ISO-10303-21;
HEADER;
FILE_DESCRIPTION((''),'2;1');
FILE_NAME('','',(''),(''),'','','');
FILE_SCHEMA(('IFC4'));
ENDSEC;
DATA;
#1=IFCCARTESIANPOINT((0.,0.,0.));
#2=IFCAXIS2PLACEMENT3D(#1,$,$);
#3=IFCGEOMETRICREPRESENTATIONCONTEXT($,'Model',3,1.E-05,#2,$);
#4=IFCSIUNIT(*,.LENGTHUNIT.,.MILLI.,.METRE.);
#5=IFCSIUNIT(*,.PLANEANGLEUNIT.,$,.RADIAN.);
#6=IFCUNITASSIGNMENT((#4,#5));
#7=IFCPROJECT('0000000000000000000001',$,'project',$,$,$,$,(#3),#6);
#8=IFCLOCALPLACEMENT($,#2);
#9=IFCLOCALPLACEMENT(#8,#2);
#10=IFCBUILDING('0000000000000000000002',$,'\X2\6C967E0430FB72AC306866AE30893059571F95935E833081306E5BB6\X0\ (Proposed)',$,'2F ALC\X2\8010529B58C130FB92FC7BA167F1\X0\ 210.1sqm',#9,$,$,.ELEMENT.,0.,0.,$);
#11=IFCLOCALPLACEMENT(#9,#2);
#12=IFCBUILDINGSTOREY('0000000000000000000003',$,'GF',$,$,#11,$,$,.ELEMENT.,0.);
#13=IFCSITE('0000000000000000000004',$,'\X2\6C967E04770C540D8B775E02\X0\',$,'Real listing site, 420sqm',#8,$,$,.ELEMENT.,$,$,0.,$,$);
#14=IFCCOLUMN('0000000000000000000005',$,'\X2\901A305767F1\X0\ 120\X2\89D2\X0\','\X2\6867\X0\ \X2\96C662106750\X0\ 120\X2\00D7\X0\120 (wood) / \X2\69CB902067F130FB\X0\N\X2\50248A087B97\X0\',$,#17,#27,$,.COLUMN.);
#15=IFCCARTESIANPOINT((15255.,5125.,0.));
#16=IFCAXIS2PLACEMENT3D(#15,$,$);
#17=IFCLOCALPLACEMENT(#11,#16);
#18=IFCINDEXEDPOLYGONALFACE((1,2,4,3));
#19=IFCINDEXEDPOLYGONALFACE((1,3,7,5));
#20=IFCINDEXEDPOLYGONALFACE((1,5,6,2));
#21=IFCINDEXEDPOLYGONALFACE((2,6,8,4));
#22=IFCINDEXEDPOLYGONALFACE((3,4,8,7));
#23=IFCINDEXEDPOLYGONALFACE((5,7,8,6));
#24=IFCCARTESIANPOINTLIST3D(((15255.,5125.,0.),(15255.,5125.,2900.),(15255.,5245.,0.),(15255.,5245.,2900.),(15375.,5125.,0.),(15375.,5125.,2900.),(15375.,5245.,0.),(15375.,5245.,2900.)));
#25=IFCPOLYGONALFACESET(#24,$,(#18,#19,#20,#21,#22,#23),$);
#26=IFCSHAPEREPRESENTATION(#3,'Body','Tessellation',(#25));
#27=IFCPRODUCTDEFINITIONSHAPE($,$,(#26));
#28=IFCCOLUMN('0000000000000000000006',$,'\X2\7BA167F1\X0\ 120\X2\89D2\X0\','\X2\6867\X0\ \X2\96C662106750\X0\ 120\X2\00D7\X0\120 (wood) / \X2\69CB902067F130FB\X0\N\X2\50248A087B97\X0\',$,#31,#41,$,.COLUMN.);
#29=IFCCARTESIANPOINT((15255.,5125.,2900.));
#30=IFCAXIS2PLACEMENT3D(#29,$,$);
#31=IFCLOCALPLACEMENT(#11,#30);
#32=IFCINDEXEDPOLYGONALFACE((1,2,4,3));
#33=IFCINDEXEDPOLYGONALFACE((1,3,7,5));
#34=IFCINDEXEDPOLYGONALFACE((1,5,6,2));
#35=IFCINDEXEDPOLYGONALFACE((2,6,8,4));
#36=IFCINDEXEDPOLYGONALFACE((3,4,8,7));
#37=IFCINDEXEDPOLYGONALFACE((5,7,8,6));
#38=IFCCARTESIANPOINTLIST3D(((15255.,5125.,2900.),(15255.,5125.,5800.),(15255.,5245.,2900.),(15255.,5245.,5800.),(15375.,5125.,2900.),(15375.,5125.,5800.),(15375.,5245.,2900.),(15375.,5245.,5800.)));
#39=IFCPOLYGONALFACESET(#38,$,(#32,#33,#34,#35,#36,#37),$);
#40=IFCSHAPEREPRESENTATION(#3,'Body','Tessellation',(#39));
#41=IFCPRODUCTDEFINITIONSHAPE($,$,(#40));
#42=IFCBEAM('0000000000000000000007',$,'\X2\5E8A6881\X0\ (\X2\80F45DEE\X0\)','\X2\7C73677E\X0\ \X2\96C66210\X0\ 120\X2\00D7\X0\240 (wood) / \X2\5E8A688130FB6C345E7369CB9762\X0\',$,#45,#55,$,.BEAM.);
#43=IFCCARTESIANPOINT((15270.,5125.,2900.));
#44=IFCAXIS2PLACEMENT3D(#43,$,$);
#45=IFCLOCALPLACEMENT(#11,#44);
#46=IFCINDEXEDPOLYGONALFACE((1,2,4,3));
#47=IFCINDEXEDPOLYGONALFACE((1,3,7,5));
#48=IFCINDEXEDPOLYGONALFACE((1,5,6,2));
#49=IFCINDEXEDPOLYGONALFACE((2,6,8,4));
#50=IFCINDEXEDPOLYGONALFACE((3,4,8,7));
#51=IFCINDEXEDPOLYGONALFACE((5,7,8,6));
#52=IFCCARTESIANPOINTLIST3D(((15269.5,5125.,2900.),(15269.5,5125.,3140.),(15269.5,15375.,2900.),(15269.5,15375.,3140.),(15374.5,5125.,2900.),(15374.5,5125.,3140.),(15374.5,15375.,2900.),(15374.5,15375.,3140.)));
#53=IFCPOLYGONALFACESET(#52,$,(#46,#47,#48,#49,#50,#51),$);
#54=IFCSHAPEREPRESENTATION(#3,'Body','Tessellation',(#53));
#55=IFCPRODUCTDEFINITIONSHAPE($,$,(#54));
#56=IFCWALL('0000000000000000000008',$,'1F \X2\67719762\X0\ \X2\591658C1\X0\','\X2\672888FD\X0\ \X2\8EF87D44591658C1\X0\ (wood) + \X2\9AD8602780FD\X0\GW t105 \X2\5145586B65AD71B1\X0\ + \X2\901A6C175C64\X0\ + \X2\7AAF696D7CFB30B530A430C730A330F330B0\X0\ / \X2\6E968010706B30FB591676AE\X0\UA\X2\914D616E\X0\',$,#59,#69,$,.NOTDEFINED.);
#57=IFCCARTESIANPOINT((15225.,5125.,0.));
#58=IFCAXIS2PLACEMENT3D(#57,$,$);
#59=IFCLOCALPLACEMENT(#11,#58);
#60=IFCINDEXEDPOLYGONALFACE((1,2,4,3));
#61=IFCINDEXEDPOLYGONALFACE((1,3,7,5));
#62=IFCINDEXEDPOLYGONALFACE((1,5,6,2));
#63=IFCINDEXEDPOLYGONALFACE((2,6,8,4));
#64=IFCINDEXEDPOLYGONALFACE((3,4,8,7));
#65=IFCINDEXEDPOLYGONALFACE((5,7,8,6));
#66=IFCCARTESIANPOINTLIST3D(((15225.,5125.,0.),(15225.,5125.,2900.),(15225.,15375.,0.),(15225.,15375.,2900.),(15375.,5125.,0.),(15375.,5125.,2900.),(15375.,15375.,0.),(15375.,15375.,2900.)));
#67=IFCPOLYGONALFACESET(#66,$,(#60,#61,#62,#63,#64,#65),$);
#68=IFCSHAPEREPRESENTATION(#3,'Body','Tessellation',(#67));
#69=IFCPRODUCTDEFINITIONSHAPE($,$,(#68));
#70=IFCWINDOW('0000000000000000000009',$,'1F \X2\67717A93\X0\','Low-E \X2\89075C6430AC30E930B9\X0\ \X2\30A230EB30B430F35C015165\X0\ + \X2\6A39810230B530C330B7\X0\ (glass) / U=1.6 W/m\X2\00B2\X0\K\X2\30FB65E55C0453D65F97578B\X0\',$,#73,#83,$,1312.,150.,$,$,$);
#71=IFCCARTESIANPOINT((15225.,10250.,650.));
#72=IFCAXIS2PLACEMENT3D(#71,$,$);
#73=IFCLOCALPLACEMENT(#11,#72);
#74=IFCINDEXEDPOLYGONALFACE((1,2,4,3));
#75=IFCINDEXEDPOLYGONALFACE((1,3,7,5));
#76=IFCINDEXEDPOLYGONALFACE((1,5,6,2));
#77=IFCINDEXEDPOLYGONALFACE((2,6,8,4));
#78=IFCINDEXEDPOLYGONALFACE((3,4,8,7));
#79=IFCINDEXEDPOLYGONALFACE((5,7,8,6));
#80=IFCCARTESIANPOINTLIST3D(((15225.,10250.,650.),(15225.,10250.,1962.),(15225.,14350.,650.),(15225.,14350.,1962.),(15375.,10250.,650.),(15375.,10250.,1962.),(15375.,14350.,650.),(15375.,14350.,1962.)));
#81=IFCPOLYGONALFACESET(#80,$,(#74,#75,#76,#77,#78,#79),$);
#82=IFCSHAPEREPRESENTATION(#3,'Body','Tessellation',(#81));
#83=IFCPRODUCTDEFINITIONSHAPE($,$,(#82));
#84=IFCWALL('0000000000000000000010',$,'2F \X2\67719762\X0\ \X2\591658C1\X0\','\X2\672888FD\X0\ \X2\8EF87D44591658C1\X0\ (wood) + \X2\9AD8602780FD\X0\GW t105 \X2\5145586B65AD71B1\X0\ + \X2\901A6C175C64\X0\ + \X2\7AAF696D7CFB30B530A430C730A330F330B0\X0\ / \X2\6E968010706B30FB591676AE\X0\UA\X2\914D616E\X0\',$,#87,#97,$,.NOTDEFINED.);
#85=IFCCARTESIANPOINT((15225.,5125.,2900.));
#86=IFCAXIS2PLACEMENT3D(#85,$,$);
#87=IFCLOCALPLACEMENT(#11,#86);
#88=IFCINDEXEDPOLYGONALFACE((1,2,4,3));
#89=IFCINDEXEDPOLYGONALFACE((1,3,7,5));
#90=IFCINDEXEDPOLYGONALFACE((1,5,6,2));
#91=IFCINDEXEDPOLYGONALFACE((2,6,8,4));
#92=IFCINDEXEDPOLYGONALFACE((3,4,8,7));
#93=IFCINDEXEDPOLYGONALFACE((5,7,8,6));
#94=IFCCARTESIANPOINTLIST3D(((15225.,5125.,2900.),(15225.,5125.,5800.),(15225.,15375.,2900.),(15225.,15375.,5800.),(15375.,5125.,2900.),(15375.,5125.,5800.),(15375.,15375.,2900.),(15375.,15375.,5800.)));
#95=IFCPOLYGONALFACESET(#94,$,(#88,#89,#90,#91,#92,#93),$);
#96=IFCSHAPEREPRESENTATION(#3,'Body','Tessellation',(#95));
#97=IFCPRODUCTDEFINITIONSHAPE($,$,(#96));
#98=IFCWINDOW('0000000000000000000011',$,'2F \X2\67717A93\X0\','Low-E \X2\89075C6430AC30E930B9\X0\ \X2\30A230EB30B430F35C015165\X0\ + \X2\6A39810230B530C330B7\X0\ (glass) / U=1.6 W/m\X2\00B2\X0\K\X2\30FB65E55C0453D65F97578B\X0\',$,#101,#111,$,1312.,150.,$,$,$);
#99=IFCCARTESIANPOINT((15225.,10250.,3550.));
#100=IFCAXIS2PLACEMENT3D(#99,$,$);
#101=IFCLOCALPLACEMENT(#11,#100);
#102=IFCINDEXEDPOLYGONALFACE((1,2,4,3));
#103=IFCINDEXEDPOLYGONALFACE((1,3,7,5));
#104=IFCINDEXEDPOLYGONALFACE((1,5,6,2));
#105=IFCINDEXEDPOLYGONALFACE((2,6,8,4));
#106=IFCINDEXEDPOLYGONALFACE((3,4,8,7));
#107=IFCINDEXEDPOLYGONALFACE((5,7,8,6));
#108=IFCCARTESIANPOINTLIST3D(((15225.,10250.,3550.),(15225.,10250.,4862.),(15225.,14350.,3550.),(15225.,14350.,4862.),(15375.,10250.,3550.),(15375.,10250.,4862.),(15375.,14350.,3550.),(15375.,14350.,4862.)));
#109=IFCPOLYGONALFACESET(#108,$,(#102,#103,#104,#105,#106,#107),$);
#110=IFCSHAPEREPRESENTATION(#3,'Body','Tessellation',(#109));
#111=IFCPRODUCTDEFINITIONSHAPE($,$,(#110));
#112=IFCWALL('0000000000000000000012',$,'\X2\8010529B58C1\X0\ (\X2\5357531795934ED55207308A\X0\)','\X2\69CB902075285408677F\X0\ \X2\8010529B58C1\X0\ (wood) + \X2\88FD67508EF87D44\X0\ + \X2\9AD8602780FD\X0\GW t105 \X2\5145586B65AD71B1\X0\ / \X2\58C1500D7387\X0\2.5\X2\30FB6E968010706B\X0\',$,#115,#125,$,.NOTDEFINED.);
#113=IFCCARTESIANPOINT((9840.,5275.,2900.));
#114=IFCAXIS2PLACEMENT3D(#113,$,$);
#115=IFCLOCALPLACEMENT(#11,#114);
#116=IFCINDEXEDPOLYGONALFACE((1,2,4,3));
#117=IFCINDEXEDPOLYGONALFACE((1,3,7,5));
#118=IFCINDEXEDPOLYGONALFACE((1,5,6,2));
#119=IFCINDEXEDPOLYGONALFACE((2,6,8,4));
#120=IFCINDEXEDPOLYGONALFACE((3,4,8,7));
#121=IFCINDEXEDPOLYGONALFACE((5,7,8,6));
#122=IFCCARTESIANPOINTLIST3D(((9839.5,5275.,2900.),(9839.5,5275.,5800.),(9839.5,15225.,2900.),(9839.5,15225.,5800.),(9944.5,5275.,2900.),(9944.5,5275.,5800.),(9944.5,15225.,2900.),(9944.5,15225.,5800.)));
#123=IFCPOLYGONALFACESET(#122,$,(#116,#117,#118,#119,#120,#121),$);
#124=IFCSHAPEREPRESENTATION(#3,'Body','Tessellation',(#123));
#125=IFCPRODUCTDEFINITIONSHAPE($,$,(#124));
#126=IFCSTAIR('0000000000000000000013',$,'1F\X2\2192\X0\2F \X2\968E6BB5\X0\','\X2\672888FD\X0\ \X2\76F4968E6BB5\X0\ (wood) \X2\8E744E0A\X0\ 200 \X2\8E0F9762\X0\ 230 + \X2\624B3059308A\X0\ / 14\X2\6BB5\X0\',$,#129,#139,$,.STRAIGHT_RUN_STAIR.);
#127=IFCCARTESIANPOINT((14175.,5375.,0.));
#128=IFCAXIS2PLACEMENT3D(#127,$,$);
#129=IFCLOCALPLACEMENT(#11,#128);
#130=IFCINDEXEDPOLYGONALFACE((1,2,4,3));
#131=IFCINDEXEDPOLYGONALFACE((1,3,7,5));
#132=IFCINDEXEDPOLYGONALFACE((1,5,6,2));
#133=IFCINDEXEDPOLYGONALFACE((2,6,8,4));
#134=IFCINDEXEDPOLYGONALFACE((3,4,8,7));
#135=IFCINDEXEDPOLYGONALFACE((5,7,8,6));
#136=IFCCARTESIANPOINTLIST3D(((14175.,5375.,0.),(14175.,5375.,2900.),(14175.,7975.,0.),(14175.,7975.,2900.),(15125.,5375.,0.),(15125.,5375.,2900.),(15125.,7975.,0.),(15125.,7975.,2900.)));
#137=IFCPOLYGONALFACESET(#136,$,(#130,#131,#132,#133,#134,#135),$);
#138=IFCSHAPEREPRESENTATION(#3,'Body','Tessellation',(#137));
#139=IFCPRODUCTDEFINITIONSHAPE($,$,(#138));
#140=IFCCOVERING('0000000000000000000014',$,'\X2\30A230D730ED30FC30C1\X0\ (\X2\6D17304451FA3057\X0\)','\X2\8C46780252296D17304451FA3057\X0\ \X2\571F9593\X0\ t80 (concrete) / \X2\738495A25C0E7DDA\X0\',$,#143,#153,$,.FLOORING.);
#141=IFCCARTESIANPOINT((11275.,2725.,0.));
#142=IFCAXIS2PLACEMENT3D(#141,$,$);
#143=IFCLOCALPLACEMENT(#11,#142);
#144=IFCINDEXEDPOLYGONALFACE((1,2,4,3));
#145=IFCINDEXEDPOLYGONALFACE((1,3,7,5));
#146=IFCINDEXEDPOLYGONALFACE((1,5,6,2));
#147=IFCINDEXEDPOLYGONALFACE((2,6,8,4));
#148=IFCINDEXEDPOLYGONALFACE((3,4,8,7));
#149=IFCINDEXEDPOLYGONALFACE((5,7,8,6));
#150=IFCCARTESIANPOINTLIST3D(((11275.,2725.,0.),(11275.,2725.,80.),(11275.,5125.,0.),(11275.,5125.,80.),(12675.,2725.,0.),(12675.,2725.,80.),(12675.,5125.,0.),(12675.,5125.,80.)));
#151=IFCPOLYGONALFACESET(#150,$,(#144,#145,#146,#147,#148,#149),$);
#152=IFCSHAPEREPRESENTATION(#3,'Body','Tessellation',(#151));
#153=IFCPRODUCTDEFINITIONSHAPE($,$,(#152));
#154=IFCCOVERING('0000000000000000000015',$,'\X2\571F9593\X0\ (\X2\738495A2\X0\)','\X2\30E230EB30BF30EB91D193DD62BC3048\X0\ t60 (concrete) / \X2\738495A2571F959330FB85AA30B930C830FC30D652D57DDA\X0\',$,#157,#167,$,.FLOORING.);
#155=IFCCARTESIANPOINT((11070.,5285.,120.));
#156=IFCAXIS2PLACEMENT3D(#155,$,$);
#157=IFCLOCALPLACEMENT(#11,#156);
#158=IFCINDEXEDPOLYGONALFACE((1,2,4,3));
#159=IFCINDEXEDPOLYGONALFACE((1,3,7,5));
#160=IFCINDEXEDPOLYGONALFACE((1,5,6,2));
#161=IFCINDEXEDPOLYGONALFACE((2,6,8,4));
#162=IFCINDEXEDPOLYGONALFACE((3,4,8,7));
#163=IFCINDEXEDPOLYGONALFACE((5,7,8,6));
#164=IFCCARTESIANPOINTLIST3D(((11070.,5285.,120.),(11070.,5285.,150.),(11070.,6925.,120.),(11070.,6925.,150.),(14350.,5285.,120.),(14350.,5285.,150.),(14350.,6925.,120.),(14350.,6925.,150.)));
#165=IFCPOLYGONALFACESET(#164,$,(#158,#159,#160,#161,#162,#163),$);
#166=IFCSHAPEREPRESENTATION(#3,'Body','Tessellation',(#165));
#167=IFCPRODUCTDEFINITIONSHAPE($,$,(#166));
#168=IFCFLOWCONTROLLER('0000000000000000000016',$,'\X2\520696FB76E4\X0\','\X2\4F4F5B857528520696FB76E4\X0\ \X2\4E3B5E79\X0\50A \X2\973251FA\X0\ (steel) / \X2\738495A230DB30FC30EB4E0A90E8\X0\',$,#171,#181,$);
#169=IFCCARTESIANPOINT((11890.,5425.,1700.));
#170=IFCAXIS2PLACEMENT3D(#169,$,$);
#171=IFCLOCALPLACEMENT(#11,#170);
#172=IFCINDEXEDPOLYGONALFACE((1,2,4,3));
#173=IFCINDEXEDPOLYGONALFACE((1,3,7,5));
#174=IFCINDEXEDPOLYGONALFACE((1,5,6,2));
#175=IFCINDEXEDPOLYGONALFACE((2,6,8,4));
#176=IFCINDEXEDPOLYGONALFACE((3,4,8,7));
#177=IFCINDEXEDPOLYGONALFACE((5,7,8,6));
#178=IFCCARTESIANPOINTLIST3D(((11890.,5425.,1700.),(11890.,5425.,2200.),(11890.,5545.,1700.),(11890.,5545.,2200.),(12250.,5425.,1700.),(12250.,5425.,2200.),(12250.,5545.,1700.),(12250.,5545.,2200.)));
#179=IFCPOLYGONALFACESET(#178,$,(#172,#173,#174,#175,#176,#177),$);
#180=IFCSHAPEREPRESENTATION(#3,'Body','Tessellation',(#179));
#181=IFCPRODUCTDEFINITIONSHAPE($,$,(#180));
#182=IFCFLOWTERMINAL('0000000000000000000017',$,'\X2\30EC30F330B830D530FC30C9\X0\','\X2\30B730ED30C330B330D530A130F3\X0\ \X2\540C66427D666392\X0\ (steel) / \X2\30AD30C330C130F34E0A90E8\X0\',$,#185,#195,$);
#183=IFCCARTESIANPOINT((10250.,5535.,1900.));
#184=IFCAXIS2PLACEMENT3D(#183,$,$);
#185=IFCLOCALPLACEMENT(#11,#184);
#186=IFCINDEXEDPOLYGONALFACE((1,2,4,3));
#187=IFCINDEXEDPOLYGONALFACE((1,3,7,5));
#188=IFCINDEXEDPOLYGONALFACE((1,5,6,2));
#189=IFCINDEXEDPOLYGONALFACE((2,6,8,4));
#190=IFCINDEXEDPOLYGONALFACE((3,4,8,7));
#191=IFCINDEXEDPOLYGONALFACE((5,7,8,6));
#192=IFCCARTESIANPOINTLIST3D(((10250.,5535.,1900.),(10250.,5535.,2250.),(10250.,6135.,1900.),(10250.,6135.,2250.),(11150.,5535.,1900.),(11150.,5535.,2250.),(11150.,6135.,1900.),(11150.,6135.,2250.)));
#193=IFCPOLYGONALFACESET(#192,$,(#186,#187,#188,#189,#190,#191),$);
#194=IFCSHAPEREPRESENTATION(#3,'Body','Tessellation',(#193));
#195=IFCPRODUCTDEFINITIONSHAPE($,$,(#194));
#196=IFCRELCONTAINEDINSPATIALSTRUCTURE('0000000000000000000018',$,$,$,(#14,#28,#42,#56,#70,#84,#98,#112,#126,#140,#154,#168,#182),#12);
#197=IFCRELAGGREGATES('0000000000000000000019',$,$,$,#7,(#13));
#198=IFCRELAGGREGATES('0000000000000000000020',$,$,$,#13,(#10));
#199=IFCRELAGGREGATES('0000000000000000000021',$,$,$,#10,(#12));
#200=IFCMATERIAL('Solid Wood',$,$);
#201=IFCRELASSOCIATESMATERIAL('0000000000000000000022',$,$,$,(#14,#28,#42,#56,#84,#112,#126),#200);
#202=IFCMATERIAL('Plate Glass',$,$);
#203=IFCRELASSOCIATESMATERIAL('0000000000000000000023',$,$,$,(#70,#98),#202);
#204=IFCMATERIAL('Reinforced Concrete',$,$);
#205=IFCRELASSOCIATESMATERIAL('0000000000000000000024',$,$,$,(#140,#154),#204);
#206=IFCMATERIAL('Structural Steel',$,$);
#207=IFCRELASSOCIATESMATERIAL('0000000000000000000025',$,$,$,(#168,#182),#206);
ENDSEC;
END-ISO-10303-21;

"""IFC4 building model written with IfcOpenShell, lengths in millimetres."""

from ifc_helpers import new_model, si_unit, frame, frame_2d, origin, place, context, project, spatial, rectangle, extrude, material, element, fill, save


model = new_model("IFC4")

# Units and contexts
model_context = context("Model", 3, precision=1e-05, world=origin())
ifc_project = project(units=[si_unit("LENGTHUNIT", "METRE", prefix="MILLI"), si_unit("PLANEANGLEUNIT", "RADIAN")], contexts=[model_context])

# Site, building, storey
site_placement = place(None, origin())
site = spatial("IfcSite", under=ifc_project, at=site_placement, Name="沖縄県名護市", ObjectType="Real listing site, 420sqm", CompositionType="ELEMENT", RefElevation=0.0)
building_placement = place(site_placement, origin())
building = spatial("IfcBuilding", under=site, at=building_placement, Name="沖縄・犬と暮らす土間広めの家 (Proposed)", ObjectType="2F ALC耐力壁・鋼管柱 210.1sqm", CompositionType="ELEMENT", ElevationOfRefHeight=0.0, ElevationOfTerrain=0.0)
storey_placement = place(building_placement, origin())
storey = spatial("IfcBuildingStorey", under=building, at=storey_placement, Name="GF", CompositionType="ELEMENT", Elevation=0.0)

# Columns
ifc_material_1 = material(Name="Solid Wood")
column_1_placement = place(storey_placement, frame((15255.0, 5125.0, 0.0)))
element("IfcColumn", 1, at=column_1_placement, inside=storey, material=ifc_material_1, Name="通し柱 120角", Description="桧 集成材 120×120 (wood) / 構造柱・N値計算", PredefinedType="COLUMN", context=model_context, shape_type="SweptSolid", body=[
    extrude(rectangle(XDim=120.0, YDim=120.0, at=frame_2d((60.0, 60.0))), frame((15255.0, 5125.0, 0.0)), (0.0, 0.0, 1.0), 2900.0),
])
column_2_placement = place(storey_placement, frame((15255.0, 5125.0, 2900.0)))
element("IfcColumn", 2, at=column_2_placement, inside=storey, material=ifc_material_1, Name="管柱 120角", Description="桧 集成材 120×120 (wood) / 構造柱・N値計算", PredefinedType="COLUMN", context=model_context, shape_type="SweptSolid", body=[
    extrude(rectangle(XDim=120.0, YDim=120.0, at=frame_2d((60.0, 60.0))), frame((15255.0, 5125.0, 2900.0)), (0.0, 0.0, 1.0), 2900.0),
])

# Beam
beam_1_placement = place(storey_placement, frame((15270.0, 5125.0, 2900.0)))
element("IfcBeam", 3, at=beam_1_placement, inside=storey, material=ifc_material_1, Name="床梁 (胴差)", Description="米松 集成 120×240 (wood) / 床梁・水平構面", PredefinedType="BEAM", context=model_context, shape_type="SweptSolid", body=[
    extrude(rectangle(XDim=105.0, YDim=10250.0, at=frame_2d((52.0, 5125.0))), frame((15270.0, 5125.0, 2900.0)), (0.0, 0.0, 1.0), 240.0),
])

# Wall, opening, window
wall_1_placement = place(storey_placement, frame((15225.0, 5125.0, 0.0)))
wall_1 = element("IfcWall", 4, at=wall_1_placement, inside=storey, material=ifc_material_1, Name="1F 東面 外壁", Description="木製 軸組外壁 (wood) + 高性能GW t105 充填断熱 + 通気層 + 窯業系サイディング / 準耐火・外皮UA配慮", PredefinedType="NOTDEFINED", context=model_context, shape_type="SweptSolid", body=[
    extrude(rectangle(XDim=150.0, YDim=10250.0, at=frame_2d((75.0, 5125.0))), frame((15225.0, 5125.0, 0.0)), (0.0, 0.0, 1.0), 2900.0),
])
opening_1_placement = place(storey_placement, frame((15225.0, 10250.0, 650.0)))
opening_1 = element("IfcOpeningElement", 5, at=opening_1_placement, cuts=wall_1, PredefinedType="NOTDEFINED", context=model_context, shape_type="SweptSolid", body=[
    extrude(rectangle(XDim=150.0, YDim=4100.0, at=frame_2d((75.0, 2050.0))), frame((15225.0, 10250.0, 650.0)), (0.0, 0.0, 1.0), 1312.0),
])
ifc_material_2 = material(Name="Plate Glass")
window_1_placement = place(storey_placement, frame((15225.0, 10250.0, 650.0)))
window_1 = element("IfcWindow", 6, at=window_1_placement, inside=storey, material=ifc_material_2, Name="1F 東窓", Description="Low-E 複層ガラス アルゴン封入 + 樹脂サッシ (glass) / U=1.6 W/m²K・日射取得型", OverallHeight=1312.0, OverallWidth=150.0, context=model_context, shape_type="SweptSolid", body=[
    extrude(rectangle(XDim=150.0, YDim=4100.0, at=frame_2d((75.0, 2050.0))), frame((15225.0, 10250.0, 650.0)), (0.0, 0.0, 1.0), 1312.0),
])
fill(opening_1, window_1)

# Wall, opening, window
wall_2_placement = place(storey_placement, frame((15225.0, 5125.0, 2900.0)))
wall_2 = element("IfcWall", 7, at=wall_2_placement, inside=storey, material=ifc_material_1, Name="2F 東面 外壁", Description="木製 軸組外壁 (wood) + 高性能GW t105 充填断熱 + 通気層 + 窯業系サイディング / 準耐火・外皮UA配慮", PredefinedType="NOTDEFINED", context=model_context, shape_type="SweptSolid", body=[
    extrude(rectangle(XDim=150.0, YDim=10250.0, at=frame_2d((75.0, 5125.0))), frame((15225.0, 5125.0, 2900.0)), (0.0, 0.0, 1.0), 2900.0),
])
opening_2_placement = place(storey_placement, frame((15225.0, 10250.0, 3550.0)))
opening_2 = element("IfcOpeningElement", 8, at=opening_2_placement, cuts=wall_2, PredefinedType="NOTDEFINED", context=model_context, shape_type="SweptSolid", body=[
    extrude(rectangle(XDim=150.0, YDim=4100.0, at=frame_2d((75.0, 2050.0))), frame((15225.0, 10250.0, 3550.0)), (0.0, 0.0, 1.0), 1312.0),
])
window_2_placement = place(storey_placement, frame((15225.0, 10250.0, 3550.0)))
window_2 = element("IfcWindow", 9, at=window_2_placement, inside=storey, material=ifc_material_2, Name="2F 東窓", Description="Low-E 複層ガラス アルゴン封入 + 樹脂サッシ (glass) / U=1.6 W/m²K・日射取得型", OverallHeight=1312.0, OverallWidth=150.0, context=model_context, shape_type="SweptSolid", body=[
    extrude(rectangle(XDim=150.0, YDim=4100.0, at=frame_2d((75.0, 2050.0))), frame((15225.0, 10250.0, 3550.0)), (0.0, 0.0, 1.0), 1312.0),
])
fill(opening_2, window_2)

# Wall
wall_3_placement = place(storey_placement, frame((9840.0, 5275.0, 2900.0)))
element("IfcWall", 10, at=wall_3_placement, inside=storey, material=ifc_material_1, Name="耐力壁 (南北間仕切り)", Description="構造用合板 耐力壁 (wood) + 製材軸組 + 高性能GW t105 充填断熱 / 壁倍率2.5・準耐火", PredefinedType="NOTDEFINED", context=model_context, shape_type="SweptSolid", body=[
    extrude(rectangle(XDim=105.0, YDim=9950.0, at=frame_2d((52.0, 4975.0))), frame((9840.0, 5275.0, 2900.0)), (0.0, 0.0, 1.0), 2900.0),
])

# Stair
stair_placement = place(storey_placement, frame((14175.0, 5375.0, 0.0)))
element("IfcStair", 11, at=stair_placement, inside=storey, material=ifc_material_1, Name="1F→2F 階段", Description="木製 直階段 (wood) 蹴上 200 踏面 230 + 手すり / 14段", PredefinedType="STRAIGHT_RUN_STAIR", context=model_context, shape_type="SweptSolid", body=[
    extrude(rectangle(XDim=950.0, YDim=2600.0, at=frame_2d((475.0, 1300.0))), frame((14175.0, 5375.0, 0.0)), (0.0, 0.0, 1.0), 2900.0),
])

# Coverings
ifc_material_3 = material(Name="Reinforced Concrete")
covering_1_placement = place(storey_placement, frame((11275.0, 2725.0, 0.0)))
element("IfcCovering", 12, at=covering_1_placement, inside=storey, material=ifc_material_3, Name="アプローチ (洗い出し)", Description="豆砂利洗い出し 土間 t80 (concrete) / 玄関導線", PredefinedType="FLOORING", context=model_context, shape_type="SweptSolid", body=[
    extrude(rectangle(XDim=1400.0, YDim=2400.0, at=frame_2d((700.0, 1200.0))), frame((11275.0, 2725.0, 0.0)), (0.0, 0.0, 1.0), 80.0),
])
covering_2_placement = place(storey_placement, frame((11070.0, 5285.0, 120.0)))
element("IfcCovering", 13, at=covering_2_placement, inside=storey, material=ifc_material_3, Name="土間 (玄関)", Description="モルタル金鏝押え t60 (concrete) / 玄関土間・薪ストーブ動線", PredefinedType="FLOORING", context=model_context, shape_type="SweptSolid", body=[
    extrude(rectangle(XDim=3280.0, YDim=1640.0, at=frame_2d((1640.0, 820.0))), frame((11070.0, 5285.0, 120.0)), (0.0, 0.0, 1.0), 30.0),
])

# Flow controller
ifc_material_4 = material(Name="Structural Steel")
flow_controller_placement = place(storey_placement, frame((11890.0, 5425.0, 1700.0)))
element("IfcFlowController", 14, at=flow_controller_placement, inside=storey, material=ifc_material_4, Name="分電盤", Description="住宅用分電盤 主幹50A 露出 (steel) / 玄関ホール上部", context=model_context, shape_type="SweptSolid", body=[
    extrude(rectangle(XDim=360.0, YDim=120.0, at=frame_2d((180.0, 60.0))), frame((11890.0, 5425.0, 1700.0)), (0.0, 0.0, 1.0), 500.0),
])

# Flow terminal
flow_terminal_1_placement = place(storey_placement, frame((10250.0, 5535.0, 1900.0)))
element("IfcFlowTerminal", 15, at=flow_terminal_1_placement, inside=storey, material=ifc_material_4, Name="レンジフード", Description="シロッコファン 同時給排 (steel) / キッチン上部", context=model_context, shape_type="SweptSolid", body=[
    extrude(rectangle(XDim=900.0, YDim=600.0, at=frame_2d((450.0, 300.0))), frame((10250.0, 5535.0, 1900.0)), (0.0, 0.0, 1.0), 350.0),
])

save(model, "model.ifc")
